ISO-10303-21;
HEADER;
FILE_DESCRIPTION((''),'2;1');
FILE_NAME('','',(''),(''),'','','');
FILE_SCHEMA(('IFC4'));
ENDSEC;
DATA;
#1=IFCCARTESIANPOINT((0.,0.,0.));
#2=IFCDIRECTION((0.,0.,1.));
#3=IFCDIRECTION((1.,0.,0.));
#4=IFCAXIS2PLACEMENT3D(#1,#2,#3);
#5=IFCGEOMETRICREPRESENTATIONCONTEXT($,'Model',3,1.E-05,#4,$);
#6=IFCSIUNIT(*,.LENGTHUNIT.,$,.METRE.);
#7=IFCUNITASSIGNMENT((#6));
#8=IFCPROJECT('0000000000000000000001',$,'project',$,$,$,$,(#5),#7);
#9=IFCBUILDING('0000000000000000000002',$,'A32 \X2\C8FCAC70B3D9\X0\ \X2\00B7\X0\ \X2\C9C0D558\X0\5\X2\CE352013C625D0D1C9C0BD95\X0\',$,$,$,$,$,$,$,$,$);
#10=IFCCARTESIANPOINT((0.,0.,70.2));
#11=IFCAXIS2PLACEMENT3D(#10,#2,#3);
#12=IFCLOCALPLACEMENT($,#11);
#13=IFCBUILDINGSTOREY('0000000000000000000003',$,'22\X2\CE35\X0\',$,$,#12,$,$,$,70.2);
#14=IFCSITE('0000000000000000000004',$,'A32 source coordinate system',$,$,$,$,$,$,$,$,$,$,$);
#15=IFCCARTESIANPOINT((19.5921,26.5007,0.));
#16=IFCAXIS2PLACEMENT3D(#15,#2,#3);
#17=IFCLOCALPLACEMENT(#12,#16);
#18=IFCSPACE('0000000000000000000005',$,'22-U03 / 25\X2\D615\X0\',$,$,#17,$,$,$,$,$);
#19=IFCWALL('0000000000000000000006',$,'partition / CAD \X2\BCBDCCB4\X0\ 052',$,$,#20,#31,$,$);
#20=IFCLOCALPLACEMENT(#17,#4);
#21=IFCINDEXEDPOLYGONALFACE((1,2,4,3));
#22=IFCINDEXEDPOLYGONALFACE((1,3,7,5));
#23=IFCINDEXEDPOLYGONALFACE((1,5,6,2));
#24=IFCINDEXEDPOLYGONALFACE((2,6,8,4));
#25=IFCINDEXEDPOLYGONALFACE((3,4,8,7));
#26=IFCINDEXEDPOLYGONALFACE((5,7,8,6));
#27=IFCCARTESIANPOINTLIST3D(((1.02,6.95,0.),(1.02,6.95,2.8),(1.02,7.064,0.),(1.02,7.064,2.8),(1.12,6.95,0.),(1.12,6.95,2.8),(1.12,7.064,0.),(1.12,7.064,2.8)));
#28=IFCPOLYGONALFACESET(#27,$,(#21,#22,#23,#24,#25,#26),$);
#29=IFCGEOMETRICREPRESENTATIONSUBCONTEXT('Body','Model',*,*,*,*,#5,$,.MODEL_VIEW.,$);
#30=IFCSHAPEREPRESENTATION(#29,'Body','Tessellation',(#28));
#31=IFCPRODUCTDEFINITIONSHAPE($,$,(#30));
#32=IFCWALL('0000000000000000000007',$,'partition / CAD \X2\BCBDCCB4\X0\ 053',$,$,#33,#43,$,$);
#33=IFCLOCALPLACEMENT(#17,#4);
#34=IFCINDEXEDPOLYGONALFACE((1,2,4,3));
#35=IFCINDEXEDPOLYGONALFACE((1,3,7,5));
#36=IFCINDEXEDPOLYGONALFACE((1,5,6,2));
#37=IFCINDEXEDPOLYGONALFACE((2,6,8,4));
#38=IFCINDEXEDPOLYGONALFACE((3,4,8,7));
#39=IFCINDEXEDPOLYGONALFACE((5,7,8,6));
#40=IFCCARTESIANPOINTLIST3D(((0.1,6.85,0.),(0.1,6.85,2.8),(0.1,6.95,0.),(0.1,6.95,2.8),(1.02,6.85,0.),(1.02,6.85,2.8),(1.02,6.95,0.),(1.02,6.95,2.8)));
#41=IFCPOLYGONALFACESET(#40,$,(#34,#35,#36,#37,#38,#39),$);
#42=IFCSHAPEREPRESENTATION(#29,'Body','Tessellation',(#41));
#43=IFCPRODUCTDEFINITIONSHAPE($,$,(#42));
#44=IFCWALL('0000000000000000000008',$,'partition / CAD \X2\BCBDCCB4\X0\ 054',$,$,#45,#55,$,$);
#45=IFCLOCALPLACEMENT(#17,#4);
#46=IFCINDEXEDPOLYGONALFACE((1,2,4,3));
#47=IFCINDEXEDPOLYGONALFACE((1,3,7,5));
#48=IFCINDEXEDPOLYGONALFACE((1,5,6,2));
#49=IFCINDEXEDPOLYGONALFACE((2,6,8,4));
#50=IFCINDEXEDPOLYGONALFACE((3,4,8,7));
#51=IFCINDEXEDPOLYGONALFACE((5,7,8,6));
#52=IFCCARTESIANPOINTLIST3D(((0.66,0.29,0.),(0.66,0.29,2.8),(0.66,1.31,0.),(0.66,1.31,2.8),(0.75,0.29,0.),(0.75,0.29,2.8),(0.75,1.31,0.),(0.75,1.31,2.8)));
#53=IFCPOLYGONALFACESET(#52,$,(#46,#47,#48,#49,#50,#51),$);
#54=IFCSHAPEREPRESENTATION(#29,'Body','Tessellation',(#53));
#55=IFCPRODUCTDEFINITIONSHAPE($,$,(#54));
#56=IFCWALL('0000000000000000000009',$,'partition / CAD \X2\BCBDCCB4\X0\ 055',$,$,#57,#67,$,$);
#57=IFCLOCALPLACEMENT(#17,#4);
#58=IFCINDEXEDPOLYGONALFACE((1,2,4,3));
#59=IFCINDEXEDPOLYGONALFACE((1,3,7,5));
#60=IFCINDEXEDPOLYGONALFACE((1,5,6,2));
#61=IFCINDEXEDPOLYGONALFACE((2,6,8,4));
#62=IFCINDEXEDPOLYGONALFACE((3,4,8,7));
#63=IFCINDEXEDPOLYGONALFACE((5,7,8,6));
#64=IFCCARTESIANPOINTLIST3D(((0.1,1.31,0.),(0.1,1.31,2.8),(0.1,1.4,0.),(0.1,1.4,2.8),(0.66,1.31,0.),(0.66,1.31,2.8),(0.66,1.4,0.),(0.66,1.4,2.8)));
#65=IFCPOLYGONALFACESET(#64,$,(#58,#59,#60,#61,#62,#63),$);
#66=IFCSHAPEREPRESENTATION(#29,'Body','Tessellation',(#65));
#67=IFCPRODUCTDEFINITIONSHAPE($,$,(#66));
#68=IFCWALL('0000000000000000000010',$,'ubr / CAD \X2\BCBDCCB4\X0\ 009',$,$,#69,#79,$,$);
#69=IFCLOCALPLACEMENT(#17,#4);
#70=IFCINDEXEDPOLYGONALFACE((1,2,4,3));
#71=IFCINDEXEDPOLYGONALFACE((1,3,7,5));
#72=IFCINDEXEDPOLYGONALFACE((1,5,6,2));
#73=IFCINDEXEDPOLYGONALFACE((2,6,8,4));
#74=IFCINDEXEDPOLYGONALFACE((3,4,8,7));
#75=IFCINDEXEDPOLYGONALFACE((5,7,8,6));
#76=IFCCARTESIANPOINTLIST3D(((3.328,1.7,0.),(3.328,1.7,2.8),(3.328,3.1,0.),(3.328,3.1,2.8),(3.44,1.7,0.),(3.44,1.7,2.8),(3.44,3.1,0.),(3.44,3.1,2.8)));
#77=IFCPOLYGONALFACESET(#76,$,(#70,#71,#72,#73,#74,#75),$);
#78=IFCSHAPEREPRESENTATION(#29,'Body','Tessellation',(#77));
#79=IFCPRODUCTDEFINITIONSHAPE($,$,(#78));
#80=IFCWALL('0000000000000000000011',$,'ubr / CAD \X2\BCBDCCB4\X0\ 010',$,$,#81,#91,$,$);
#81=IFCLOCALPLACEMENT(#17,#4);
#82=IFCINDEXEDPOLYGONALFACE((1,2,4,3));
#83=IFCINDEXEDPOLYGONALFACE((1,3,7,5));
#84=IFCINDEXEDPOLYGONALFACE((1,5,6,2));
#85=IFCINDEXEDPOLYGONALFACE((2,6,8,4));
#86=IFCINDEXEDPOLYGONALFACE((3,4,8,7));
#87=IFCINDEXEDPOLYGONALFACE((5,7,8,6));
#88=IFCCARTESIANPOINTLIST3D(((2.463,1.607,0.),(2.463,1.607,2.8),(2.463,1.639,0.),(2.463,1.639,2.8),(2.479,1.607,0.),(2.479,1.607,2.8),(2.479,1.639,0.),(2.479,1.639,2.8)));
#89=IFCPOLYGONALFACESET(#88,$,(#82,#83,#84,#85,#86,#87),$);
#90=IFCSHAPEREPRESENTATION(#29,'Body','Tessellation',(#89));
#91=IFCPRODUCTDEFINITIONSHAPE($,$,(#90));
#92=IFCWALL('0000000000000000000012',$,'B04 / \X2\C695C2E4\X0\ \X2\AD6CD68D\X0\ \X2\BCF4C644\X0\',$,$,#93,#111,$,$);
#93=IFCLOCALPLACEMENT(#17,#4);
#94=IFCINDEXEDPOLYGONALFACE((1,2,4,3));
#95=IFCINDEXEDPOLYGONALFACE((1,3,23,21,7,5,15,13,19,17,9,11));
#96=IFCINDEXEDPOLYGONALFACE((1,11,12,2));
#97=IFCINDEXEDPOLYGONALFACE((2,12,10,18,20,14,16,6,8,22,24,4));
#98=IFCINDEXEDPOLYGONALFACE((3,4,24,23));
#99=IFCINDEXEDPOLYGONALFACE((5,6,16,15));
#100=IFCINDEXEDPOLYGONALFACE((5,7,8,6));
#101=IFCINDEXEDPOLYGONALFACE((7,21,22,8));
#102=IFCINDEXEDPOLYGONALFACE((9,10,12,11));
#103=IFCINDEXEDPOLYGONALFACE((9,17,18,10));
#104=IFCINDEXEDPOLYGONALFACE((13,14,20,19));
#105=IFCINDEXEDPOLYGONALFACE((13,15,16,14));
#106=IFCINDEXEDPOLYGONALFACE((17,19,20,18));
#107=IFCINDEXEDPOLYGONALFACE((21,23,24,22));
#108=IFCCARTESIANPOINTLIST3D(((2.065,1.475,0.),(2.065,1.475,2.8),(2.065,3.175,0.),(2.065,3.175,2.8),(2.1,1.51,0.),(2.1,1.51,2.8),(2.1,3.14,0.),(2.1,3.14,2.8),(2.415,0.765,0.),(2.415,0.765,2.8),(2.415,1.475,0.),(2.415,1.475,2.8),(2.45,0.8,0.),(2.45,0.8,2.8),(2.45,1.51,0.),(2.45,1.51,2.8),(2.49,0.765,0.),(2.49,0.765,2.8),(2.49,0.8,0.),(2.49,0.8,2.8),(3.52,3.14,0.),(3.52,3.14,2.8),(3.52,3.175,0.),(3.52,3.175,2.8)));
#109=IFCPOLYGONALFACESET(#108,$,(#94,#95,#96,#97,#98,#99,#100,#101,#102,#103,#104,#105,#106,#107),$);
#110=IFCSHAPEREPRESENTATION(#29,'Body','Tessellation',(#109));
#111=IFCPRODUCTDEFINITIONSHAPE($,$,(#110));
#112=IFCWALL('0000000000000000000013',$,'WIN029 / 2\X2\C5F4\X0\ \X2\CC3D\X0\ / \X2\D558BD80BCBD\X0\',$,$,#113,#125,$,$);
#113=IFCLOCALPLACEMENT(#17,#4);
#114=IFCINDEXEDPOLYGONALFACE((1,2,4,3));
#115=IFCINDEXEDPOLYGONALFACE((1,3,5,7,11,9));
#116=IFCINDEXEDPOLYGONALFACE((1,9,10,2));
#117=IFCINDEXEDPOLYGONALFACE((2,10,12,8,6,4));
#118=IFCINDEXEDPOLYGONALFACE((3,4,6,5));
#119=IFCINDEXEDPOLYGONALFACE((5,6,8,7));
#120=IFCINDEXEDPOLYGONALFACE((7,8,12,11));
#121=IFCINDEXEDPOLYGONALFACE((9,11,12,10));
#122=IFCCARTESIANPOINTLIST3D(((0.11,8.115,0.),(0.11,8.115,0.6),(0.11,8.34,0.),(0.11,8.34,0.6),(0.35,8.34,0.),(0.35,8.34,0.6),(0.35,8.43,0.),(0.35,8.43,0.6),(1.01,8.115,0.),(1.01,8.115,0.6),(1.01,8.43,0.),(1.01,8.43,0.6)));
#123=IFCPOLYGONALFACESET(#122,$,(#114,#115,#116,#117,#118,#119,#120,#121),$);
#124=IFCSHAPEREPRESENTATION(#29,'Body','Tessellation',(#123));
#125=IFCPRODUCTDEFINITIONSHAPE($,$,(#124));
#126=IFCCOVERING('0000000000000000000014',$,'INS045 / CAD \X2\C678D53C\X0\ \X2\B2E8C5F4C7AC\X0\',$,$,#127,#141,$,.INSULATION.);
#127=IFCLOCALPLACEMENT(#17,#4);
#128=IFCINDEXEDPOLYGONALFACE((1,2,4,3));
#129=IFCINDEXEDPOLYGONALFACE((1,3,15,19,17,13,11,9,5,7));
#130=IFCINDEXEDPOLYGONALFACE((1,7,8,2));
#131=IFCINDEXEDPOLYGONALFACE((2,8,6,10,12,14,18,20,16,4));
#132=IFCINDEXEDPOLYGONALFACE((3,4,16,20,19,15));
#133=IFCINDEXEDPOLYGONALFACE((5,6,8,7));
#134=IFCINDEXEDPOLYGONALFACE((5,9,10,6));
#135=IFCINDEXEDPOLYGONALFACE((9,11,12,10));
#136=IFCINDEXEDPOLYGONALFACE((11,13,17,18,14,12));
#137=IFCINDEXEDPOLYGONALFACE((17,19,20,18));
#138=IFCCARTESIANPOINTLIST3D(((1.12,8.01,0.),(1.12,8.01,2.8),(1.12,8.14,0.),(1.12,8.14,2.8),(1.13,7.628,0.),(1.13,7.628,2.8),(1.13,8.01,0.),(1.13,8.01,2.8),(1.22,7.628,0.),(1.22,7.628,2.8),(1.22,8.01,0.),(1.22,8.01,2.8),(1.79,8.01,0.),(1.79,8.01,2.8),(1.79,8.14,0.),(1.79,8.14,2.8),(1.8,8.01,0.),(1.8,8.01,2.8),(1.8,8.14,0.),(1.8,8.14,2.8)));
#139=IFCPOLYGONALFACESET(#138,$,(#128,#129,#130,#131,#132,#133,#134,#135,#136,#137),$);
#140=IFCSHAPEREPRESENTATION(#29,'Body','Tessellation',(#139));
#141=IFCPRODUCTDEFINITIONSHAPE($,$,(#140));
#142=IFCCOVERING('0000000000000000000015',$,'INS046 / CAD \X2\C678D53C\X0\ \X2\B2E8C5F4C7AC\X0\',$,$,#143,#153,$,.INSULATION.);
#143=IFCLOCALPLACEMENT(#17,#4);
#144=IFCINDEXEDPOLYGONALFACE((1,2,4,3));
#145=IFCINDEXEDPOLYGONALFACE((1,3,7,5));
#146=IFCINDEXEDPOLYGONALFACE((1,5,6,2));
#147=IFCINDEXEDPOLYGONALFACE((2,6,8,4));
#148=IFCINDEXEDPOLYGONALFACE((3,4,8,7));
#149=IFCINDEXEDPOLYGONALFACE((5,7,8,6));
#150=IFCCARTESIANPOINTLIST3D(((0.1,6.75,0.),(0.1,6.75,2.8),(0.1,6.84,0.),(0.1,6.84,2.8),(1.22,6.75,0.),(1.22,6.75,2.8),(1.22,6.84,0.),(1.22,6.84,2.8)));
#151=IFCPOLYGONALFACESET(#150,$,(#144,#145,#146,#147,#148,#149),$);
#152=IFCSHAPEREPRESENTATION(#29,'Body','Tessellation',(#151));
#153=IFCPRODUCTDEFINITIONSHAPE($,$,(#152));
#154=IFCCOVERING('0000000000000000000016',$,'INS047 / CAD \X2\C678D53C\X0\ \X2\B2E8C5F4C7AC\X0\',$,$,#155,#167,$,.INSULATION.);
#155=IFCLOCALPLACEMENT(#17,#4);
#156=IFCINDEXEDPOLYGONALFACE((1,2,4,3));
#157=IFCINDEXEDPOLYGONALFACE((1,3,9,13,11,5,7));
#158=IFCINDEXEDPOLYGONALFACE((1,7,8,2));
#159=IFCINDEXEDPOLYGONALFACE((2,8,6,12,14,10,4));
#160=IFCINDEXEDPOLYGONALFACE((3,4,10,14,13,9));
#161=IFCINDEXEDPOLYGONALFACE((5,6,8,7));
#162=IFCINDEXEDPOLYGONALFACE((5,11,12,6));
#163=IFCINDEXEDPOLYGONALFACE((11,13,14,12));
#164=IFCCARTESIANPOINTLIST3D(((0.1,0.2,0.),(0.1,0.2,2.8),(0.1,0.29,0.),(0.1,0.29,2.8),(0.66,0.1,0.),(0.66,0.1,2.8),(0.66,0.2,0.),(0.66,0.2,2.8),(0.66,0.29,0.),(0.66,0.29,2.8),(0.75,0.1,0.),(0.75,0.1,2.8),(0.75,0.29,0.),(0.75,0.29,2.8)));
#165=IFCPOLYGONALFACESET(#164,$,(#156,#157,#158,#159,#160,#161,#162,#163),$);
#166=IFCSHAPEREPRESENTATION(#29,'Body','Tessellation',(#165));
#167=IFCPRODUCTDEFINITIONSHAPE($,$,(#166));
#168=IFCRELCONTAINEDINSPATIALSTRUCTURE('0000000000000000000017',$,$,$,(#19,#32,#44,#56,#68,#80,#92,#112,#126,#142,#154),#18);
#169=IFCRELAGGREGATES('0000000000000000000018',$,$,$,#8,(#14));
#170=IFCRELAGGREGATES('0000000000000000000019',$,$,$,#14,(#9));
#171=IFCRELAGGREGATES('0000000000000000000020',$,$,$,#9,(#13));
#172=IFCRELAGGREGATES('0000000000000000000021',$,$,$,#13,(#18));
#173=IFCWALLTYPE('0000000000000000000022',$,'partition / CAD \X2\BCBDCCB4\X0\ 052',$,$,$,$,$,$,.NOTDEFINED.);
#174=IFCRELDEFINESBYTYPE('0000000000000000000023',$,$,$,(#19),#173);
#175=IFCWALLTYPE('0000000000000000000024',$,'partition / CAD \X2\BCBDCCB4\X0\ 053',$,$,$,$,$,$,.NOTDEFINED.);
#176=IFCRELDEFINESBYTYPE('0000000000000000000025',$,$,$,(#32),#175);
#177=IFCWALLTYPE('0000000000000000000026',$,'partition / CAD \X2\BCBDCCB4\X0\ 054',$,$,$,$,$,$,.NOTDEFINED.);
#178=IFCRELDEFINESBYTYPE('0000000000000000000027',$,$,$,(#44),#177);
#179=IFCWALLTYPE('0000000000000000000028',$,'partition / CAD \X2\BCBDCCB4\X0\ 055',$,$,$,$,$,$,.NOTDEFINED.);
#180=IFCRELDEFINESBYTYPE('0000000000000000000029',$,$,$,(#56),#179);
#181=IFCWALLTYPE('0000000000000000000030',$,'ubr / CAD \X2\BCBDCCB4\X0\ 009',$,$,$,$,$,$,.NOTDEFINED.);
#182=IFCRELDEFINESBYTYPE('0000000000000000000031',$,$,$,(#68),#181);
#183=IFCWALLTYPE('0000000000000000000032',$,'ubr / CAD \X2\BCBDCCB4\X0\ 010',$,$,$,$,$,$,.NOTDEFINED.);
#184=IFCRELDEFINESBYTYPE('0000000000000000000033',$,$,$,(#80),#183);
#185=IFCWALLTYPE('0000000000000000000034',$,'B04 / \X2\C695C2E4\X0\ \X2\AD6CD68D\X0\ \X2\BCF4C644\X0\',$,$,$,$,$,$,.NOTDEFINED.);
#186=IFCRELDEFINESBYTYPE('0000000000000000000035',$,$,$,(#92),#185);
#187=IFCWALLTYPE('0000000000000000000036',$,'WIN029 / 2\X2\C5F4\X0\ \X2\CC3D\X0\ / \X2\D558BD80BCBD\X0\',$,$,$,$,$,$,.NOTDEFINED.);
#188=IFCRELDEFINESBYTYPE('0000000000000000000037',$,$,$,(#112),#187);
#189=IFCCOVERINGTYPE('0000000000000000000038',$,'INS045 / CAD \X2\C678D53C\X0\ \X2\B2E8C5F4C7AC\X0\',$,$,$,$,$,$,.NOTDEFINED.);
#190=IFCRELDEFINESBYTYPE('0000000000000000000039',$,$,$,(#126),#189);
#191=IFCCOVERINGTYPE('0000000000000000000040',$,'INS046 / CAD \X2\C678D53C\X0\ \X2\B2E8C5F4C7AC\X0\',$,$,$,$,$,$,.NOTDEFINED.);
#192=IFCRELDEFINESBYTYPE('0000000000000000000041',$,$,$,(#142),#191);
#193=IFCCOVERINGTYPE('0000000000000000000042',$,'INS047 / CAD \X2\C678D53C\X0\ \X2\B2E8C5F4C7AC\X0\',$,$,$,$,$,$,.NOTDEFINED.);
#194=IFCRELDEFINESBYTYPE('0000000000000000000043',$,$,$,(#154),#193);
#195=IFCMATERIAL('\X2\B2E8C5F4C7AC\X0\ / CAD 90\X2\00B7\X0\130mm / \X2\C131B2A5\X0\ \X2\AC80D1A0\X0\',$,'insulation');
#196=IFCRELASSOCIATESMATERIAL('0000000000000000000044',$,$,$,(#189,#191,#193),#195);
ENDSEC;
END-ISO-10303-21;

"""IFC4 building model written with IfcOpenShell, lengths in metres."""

from ifc_helpers import new_model, si_unit, frame, origin, origin_with_axes, place, context, subcontext, project, spatial, polyline, outline, extrude, source, transform, mapped, material, type_object, type_shapes, element, save


model = new_model("IFC4")

# Units and contexts
model_context = context("Model", 3, precision=1e-05, world=origin_with_axes())
body_context = subcontext(model_context, "Body", "Model", "MODEL_VIEW")
ifc_project = project(units=[si_unit("LENGTHUNIT", "METRE")], contexts=[model_context])

# Site, building, storey, space
storey_placement = place(None, frame((0.0, 0.0, 70.2), z_axis=(0.0, 0.0, 1.0), x_axis=(1.0, 0.0, 0.0)))
space_placement = place(storey_placement, frame((19.5921, 26.5007, 0.0), z_axis=(0.0, 0.0, 1.0), x_axis=(1.0, 0.0, 0.0)))
site = spatial("IfcSite", under=ifc_project, Name="A32 source coordinate system")
building = spatial("IfcBuilding", under=site, Name="A32 주거동 · 지하5층–옥탑지붕")
storey = spatial("IfcBuildingStorey", under=building, at=storey_placement, Name="22층", Elevation=70.2)
space = spatial("IfcSpace", under=storey, at=space_placement, Name="22-U03 / 25형")

# Walls
wall_type_1 = type_object("IfcWallType", Name="partition / CAD 벽체 052", PredefinedType="NOTDEFINED")
shared_shape_1 = source(origin(), body_context, "Body", "SweptSolid", [
    extrude(outline(polyline([(1.12, 6.95), (1.02, 6.95), (1.02, 7.064), (1.12, 7.064), (1.12, 6.95)])), origin(), (0.0, 0.0, 1.0), 2.8),
])
type_shapes(wall_type_1, [shared_shape_1])
wall_1_placement = place(space_placement, origin_with_axes())
element("IfcWall", 1, at=wall_1_placement, inside=space, type_object=wall_type_1, Name="partition / CAD 벽체 052", context=body_context, shape_type="MappedRepresentation", body=[
    mapped(shared_shape_1, transform((0.0, 0.0, 0.0), scale=1.0)),
])
wall_type_2 = type_object("IfcWallType", Name="partition / CAD 벽체 053", PredefinedType="NOTDEFINED")
shared_shape_2 = source(origin(), body_context, "Body", "SweptSolid", [
    extrude(outline(polyline([(1.02, 6.95), (1.02, 6.85), (0.1, 6.85), (0.1, 6.95), (1.02, 6.95)])), origin(), (0.0, 0.0, 1.0), 2.8),
])
type_shapes(wall_type_2, [shared_shape_2])
wall_2_placement = place(space_placement, origin_with_axes())
element("IfcWall", 2, at=wall_2_placement, inside=space, type_object=wall_type_2, Name="partition / CAD 벽체 053", context=body_context, shape_type="MappedRepresentation", body=[
    mapped(shared_shape_2, transform((0.0, 0.0, 0.0), scale=1.0)),
])
wall_type_3 = type_object("IfcWallType", Name="partition / CAD 벽체 054", PredefinedType="NOTDEFINED")
shared_shape_3 = source(origin(), body_context, "Body", "SweptSolid", [
    extrude(outline(polyline([(0.75, 0.29), (0.66, 0.29), (0.66, 1.31), (0.75, 1.31), (0.75, 0.29)])), origin(), (0.0, 0.0, 1.0), 2.8),
])
type_shapes(wall_type_3, [shared_shape_3])
wall_3_placement = place(space_placement, origin_with_axes())
element("IfcWall", 3, at=wall_3_placement, inside=space, type_object=wall_type_3, Name="partition / CAD 벽체 054", context=body_context, shape_type="MappedRepresentation", body=[
    mapped(shared_shape_3, transform((0.0, 0.0, 0.0), scale=1.0)),
])
wall_type_4 = type_object("IfcWallType", Name="partition / CAD 벽체 055", PredefinedType="NOTDEFINED")
shared_shape_4 = source(origin(), body_context, "Body", "SweptSolid", [
    extrude(outline(polyline([(0.66, 1.4), (0.66, 1.31), (0.1, 1.31), (0.1, 1.4), (0.66, 1.4)])), origin(), (0.0, 0.0, 1.0), 2.8),
])
type_shapes(wall_type_4, [shared_shape_4])
wall_4_placement = place(space_placement, origin_with_axes())
element("IfcWall", 4, at=wall_4_placement, inside=space, type_object=wall_type_4, Name="partition / CAD 벽체 055", context=body_context, shape_type="MappedRepresentation", body=[
    mapped(shared_shape_4, transform((0.0, 0.0, 0.0), scale=1.0)),
])
wall_type_5 = type_object("IfcWallType", Name="ubr / CAD 벽체 009", PredefinedType="NOTDEFINED")
shared_shape_5 = source(origin(), body_context, "Body", "SweptSolid", [
    extrude(outline(polyline([(3.328, 3.1), (3.44, 3.1), (3.44, 1.7), (3.328, 1.7), (3.328, 3.1)])), origin(), (0.0, 0.0, 1.0), 2.8),
])
type_shapes(wall_type_5, [shared_shape_5])
wall_5_placement = place(space_placement, origin_with_axes())
element("IfcWall", 5, at=wall_5_placement, inside=space, type_object=wall_type_5, Name="ubr / CAD 벽체 009", context=body_context, shape_type="MappedRepresentation", body=[
    mapped(shared_shape_5, transform((0.0, 0.0, 0.0), scale=1.0)),
])
wall_type_6 = type_object("IfcWallType", Name="ubr / CAD 벽체 010", PredefinedType="NOTDEFINED")
shared_shape_6 = source(origin(), body_context, "Body", "SweptSolid", [
    extrude(outline(polyline([(2.463, 1.607), (2.463, 1.639), (2.479, 1.639), (2.479, 1.607), (2.463, 1.607)])), origin(), (0.0, 0.0, 1.0), 2.8),
])
type_shapes(wall_type_6, [shared_shape_6])
wall_6_placement = place(space_placement, origin_with_axes())
element("IfcWall", 6, at=wall_6_placement, inside=space, type_object=wall_type_6, Name="ubr / CAD 벽체 010", context=body_context, shape_type="MappedRepresentation", body=[
    mapped(shared_shape_6, transform((0.0, 0.0, 0.0), scale=1.0)),
])
wall_type_7 = type_object("IfcWallType", Name="B04 / 욕실 구획 보완", PredefinedType="NOTDEFINED")
shared_shape_7 = source(origin(), body_context, "Body", "SweptSolid", [
    extrude(outline(polyline([(3.52, 3.175), (3.52, 3.14), (2.1, 3.14), (2.1, 1.51), (2.45, 1.51), (2.45, 0.8), (2.49, 0.8), (2.49, 0.765), (2.415, 0.765), (2.415, 1.475), (2.065, 1.475), (2.065, 3.175), (3.52, 3.175)])), origin(), (0.0, 0.0, 1.0), 2.8),
])
type_shapes(wall_type_7, [shared_shape_7])
wall_7_placement = place(space_placement, origin_with_axes())
element("IfcWall", 7, at=wall_7_placement, inside=space, type_object=wall_type_7, Name="B04 / 욕실 구획 보완", context=body_context, shape_type="MappedRepresentation", body=[
    mapped(shared_shape_7, transform((0.0, 0.0, 0.0), scale=1.0)),
])
wall_type_8 = type_object("IfcWallType", Name="WIN029 / 2열 창 / 하부벽", PredefinedType="NOTDEFINED")
shared_shape_8 = source(origin(), body_context, "Body", "SweptSolid", [
    extrude(outline(polyline([(1.01, 8.115), (0.11, 8.115), (0.11, 8.34), (0.35, 8.34), (0.35, 8.43), (1.01, 8.43), (1.01, 8.115)])), origin(), (0.0, 0.0, 1.0), 0.6),
])
type_shapes(wall_type_8, [shared_shape_8])
wall_8_placement = place(space_placement, origin_with_axes())
element("IfcWall", 8, at=wall_8_placement, inside=space, type_object=wall_type_8, Name="WIN029 / 2열 창 / 하부벽", context=body_context, shape_type="MappedRepresentation", body=[
    mapped(shared_shape_8, transform((0.0, 0.0, 0.0), scale=1.0)),
])

# Coverings
ifc_material = material(Name="단열재 / CAD 90·130mm / 성능 검토", Category="insulation")
covering_type_1 = type_object("IfcCoveringType", Name="INS045 / CAD 외피 단열재", PredefinedType="NOTDEFINED", material=ifc_material)
shared_shape_9 = source(origin(), body_context, "Body", "SweptSolid", [
    extrude(outline(polyline([(1.22, 8.01), (1.22, 7.628), (1.13, 7.628), (1.13, 8.01), (1.12, 8.01), (1.12, 8.14), (1.79, 8.14), (1.8, 8.14), (1.8, 8.01), (1.79, 8.01), (1.22, 8.01)])), origin(), (0.0, 0.0, 1.0), 2.8),
])
type_shapes(covering_type_1, [shared_shape_9])
covering_1_placement = place(space_placement, origin_with_axes())
element("IfcCovering", 9, at=covering_1_placement, inside=space, type_object=covering_type_1, Name="INS045 / CAD 외피 단열재", PredefinedType="INSULATION", context=body_context, shape_type="MappedRepresentation", body=[
    mapped(shared_shape_9, transform((0.0, 0.0, 0.0), scale=1.0)),
])
covering_type_2 = type_object("IfcCoveringType", Name="INS046 / CAD 외피 단열재", PredefinedType="NOTDEFINED", material=ifc_material)
shared_shape_10 = source(origin(), body_context, "Body", "SweptSolid", [
    extrude(outline(polyline([(0.1, 6.84), (1.22, 6.84), (1.22, 6.75), (0.1, 6.75), (0.1, 6.84)])), origin(), (0.0, 0.0, 1.0), 2.8),
])
type_shapes(covering_type_2, [shared_shape_10])
covering_2_placement = place(space_placement, origin_with_axes())
element("IfcCovering", 10, at=covering_2_placement, inside=space, type_object=covering_type_2, Name="INS046 / CAD 외피 단열재", PredefinedType="INSULATION", context=body_context, shape_type="MappedRepresentation", body=[
    mapped(shared_shape_10, transform((0.0, 0.0, 0.0), scale=1.0)),
])
covering_type_3 = type_object("IfcCoveringType", Name="INS047 / CAD 외피 단열재", PredefinedType="NOTDEFINED", material=ifc_material)
shared_shape_11 = source(origin(), body_context, "Body", "SweptSolid", [
    extrude(outline(polyline([(0.1, 0.2), (0.1, 0.29), (0.66, 0.29), (0.75, 0.29), (0.75, 0.1), (0.66, 0.1), (0.66, 0.2), (0.1, 0.2)])), origin(), (0.0, 0.0, 1.0), 2.8),
])
type_shapes(covering_type_3, [shared_shape_11])
covering_3_placement = place(space_placement, origin_with_axes())
element("IfcCovering", 11, at=covering_3_placement, inside=space, type_object=covering_type_3, Name="INS047 / CAD 외피 단열재", PredefinedType="INSULATION", context=body_context, shape_type="MappedRepresentation", body=[
    mapped(shared_shape_11, transform((0.0, 0.0, 0.0), scale=1.0)),
])

save(model, "model.ifc")
